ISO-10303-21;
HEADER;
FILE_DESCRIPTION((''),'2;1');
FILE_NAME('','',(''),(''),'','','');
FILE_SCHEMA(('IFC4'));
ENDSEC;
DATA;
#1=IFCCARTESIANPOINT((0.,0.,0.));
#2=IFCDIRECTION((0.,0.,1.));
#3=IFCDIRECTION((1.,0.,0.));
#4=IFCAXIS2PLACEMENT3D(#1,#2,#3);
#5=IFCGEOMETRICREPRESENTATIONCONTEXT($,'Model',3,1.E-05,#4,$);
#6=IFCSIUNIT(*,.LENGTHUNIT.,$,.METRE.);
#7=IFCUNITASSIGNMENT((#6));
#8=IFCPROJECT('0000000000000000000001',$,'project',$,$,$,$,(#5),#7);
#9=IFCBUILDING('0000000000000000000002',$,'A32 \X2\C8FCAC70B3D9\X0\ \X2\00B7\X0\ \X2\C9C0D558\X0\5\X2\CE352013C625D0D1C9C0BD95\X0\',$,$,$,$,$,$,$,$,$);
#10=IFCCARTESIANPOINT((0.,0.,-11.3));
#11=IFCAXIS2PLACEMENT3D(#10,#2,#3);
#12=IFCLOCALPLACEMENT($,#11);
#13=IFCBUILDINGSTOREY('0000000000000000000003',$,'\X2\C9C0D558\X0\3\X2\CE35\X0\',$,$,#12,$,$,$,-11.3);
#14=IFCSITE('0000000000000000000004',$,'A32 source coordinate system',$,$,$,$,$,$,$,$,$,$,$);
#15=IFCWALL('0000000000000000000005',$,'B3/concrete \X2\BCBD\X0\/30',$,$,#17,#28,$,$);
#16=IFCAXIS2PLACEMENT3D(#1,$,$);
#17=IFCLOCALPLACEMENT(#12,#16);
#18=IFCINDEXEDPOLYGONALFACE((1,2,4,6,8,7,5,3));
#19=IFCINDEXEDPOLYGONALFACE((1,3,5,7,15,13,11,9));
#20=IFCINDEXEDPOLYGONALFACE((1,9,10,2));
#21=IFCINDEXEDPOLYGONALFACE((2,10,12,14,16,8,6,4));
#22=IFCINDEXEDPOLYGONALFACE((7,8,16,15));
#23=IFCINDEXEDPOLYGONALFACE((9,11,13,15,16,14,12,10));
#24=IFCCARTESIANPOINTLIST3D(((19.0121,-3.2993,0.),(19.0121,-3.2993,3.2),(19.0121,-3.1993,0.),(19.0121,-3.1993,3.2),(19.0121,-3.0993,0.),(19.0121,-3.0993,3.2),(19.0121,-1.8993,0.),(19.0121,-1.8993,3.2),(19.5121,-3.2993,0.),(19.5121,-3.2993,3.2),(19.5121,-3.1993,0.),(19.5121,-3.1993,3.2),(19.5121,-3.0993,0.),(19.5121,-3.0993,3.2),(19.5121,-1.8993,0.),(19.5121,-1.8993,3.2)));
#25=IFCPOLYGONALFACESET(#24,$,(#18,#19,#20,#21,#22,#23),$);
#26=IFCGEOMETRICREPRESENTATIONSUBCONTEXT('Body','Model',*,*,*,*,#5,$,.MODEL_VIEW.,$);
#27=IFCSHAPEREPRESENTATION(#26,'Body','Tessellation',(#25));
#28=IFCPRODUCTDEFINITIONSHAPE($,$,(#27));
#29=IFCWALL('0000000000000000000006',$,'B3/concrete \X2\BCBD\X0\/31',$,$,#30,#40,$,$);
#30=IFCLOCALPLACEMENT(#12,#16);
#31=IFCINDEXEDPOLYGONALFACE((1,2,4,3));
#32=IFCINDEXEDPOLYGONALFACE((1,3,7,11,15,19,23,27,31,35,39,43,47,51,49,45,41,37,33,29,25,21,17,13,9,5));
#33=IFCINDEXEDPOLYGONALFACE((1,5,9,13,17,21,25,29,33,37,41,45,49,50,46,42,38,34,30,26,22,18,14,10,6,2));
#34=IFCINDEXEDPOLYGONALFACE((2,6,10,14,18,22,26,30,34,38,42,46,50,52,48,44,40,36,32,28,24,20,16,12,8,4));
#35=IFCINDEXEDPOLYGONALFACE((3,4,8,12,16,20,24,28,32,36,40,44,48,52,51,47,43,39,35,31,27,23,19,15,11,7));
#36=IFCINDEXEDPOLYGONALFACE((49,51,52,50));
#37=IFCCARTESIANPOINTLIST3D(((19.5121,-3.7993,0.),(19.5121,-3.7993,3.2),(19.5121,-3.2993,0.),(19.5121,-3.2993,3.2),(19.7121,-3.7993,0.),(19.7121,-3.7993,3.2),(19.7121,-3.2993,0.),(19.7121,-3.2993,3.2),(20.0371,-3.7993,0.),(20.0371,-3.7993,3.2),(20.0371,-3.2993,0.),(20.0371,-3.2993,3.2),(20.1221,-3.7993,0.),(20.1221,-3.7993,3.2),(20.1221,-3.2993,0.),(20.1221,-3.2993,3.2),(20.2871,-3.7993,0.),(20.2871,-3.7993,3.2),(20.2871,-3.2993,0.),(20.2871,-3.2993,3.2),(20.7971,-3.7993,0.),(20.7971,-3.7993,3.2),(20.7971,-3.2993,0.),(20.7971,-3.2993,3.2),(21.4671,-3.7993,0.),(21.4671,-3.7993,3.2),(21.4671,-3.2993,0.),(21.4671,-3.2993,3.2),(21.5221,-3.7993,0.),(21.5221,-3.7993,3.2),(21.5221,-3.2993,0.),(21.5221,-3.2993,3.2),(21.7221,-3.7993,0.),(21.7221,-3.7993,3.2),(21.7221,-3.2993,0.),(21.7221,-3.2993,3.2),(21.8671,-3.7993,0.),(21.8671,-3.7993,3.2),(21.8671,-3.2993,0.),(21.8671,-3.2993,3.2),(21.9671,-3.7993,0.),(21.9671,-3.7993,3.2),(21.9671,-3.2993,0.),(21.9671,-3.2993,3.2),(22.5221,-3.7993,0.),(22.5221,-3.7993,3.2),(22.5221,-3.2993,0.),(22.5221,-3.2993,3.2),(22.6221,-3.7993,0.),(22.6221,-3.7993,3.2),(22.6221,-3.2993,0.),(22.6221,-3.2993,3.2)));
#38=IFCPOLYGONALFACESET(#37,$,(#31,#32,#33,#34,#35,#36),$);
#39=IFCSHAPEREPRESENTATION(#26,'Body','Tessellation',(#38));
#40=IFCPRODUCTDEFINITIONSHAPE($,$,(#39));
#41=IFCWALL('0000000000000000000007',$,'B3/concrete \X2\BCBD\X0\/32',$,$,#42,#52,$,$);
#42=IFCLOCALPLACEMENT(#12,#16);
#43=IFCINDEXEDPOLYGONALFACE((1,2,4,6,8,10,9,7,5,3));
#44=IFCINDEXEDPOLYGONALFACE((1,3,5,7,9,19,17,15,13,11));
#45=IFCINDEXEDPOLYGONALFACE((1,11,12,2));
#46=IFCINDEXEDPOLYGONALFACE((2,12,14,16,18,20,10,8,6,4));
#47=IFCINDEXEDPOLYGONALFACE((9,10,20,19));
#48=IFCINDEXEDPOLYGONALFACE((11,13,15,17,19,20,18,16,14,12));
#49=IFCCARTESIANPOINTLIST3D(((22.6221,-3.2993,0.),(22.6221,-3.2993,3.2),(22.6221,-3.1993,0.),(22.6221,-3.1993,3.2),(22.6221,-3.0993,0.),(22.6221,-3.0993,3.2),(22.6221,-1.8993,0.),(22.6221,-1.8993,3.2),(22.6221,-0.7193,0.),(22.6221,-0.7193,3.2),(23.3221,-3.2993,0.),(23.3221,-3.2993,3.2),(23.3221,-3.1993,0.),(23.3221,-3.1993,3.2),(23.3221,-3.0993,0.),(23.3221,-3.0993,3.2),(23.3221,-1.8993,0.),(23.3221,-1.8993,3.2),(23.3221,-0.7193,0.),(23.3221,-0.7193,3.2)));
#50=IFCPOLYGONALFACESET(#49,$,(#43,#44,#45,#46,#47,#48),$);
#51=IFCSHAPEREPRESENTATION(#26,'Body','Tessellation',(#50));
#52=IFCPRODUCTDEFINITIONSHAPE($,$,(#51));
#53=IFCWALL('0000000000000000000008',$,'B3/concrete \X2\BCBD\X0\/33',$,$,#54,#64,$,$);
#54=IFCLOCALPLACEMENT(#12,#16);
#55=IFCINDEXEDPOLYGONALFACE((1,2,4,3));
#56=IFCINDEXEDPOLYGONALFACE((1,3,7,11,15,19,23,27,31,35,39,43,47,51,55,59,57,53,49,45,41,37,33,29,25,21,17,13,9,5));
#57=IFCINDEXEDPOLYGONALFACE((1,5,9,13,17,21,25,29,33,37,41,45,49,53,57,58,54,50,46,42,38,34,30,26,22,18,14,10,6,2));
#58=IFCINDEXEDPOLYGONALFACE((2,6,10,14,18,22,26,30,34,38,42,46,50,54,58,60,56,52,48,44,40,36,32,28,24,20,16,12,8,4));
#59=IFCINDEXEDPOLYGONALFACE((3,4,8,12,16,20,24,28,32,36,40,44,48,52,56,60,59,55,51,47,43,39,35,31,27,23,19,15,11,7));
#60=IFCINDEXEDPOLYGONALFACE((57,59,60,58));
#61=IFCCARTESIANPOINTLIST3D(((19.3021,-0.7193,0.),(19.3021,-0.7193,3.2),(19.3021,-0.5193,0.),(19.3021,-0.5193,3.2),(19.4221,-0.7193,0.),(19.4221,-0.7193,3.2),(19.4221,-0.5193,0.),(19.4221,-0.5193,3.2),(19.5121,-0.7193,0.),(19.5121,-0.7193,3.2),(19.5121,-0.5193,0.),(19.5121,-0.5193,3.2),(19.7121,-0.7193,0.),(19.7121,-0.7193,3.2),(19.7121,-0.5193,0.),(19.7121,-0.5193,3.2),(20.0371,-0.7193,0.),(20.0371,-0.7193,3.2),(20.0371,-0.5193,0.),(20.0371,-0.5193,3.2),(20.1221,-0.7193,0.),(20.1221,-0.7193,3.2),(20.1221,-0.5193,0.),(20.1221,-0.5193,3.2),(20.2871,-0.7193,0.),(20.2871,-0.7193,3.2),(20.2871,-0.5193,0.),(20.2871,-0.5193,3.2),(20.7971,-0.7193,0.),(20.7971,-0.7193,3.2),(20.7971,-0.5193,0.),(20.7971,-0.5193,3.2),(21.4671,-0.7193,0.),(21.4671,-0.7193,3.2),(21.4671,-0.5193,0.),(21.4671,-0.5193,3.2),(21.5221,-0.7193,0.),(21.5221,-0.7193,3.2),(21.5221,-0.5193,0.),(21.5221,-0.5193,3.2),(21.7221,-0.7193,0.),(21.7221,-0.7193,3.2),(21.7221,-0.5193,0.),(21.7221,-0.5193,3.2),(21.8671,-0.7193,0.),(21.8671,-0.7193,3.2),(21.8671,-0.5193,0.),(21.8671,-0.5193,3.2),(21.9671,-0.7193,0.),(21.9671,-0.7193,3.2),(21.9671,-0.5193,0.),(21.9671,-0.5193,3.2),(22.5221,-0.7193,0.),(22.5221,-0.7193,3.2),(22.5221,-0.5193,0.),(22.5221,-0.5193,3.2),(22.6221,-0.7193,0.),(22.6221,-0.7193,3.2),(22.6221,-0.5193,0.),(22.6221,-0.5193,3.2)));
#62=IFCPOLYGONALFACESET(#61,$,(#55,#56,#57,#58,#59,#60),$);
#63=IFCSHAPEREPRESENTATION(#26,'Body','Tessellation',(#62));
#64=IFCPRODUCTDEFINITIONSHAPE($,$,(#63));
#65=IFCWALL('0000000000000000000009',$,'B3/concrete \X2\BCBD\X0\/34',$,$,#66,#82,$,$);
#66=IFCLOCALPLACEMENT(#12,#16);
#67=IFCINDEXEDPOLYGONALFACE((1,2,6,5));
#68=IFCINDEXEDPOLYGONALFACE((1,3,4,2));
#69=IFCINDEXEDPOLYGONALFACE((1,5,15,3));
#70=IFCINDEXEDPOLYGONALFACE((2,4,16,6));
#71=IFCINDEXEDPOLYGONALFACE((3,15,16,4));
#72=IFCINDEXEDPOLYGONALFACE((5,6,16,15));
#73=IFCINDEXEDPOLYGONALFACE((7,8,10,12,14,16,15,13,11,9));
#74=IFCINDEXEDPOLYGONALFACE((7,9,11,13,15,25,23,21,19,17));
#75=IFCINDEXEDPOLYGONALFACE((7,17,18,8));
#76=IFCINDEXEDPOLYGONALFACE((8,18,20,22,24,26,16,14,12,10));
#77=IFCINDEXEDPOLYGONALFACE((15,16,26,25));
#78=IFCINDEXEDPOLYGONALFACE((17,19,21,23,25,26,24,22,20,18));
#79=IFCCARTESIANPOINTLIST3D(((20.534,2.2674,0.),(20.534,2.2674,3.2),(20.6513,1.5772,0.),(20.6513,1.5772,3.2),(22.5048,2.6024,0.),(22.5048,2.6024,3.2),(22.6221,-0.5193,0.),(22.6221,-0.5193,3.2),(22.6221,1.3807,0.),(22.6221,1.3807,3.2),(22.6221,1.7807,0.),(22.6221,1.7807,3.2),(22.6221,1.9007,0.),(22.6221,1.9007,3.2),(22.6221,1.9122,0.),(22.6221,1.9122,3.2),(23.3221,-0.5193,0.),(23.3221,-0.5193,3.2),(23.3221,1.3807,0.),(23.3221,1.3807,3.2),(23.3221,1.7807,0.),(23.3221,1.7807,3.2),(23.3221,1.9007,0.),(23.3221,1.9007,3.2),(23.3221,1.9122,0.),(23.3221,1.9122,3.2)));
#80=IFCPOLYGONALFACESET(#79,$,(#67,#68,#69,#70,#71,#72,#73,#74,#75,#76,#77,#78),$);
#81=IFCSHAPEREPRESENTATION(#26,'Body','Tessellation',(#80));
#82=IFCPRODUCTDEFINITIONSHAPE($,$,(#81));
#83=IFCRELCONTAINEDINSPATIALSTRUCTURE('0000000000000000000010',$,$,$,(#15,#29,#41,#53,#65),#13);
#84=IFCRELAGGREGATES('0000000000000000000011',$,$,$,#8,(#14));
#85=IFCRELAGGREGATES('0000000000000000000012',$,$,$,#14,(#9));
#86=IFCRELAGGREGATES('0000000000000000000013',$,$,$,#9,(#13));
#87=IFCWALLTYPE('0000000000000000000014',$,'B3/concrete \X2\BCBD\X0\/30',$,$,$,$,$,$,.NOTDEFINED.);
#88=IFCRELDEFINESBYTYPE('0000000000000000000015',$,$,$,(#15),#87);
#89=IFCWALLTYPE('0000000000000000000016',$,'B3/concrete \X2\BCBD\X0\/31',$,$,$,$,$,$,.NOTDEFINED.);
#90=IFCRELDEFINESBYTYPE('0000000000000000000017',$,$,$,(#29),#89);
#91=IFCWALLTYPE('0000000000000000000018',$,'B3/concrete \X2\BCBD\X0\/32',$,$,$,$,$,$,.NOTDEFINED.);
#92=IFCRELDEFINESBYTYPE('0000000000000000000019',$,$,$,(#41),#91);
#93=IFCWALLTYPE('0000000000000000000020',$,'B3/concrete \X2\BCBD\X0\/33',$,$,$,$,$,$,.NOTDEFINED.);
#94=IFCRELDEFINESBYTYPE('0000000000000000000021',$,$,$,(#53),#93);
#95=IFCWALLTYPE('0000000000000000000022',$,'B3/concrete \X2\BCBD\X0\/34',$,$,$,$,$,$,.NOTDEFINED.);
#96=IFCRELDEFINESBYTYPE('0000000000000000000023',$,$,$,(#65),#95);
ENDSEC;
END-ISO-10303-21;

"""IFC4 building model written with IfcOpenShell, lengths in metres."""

from ifc_helpers import new_model, si_unit, frame, origin, origin_with_axes, place, context, subcontext, project, spatial, polyline, outline, extrude, source, transform, mapped, type_object, type_shapes, element, save


model = new_model("IFC4")

# Units and contexts
model_context = context("Model", 3, precision=1e-05, world=origin_with_axes())
body_context = subcontext(model_context, "Body", "Model", "MODEL_VIEW")
ifc_project = project(units=[si_unit("LENGTHUNIT", "METRE")], contexts=[model_context])

# Site, building, storey
site = spatial("IfcSite", under=ifc_project, Name="A32 source coordinate system")
building = spatial("IfcBuilding", under=site, Name="A32 주거동 · 지하5층–옥탑지붕")
storey_placement = place(None, frame((0.0, 0.0, -11.3), z_axis=(0.0, 0.0, 1.0), x_axis=(1.0, 0.0, 0.0)))
storey = spatial("IfcBuildingStorey", under=building, at=storey_placement, Name="지하3층", Elevation=-11.3)

# Walls
wall_type_1 = type_object("IfcWallType", Name="B3/concrete 벽/30", PredefinedType="NOTDEFINED")
shared_shape_1 = source(origin(), body_context, "Body", "SweptSolid", [
    extrude(outline(polyline([(19.0121, -1.8993), (19.5121, -1.8993), (19.5121, -3.0993), (19.5121, -3.1993), (19.5121, -3.2993), (19.0121, -3.2993), (19.0121, -3.1993), (19.0121, -3.0993), (19.0121, -1.8993)])), origin(), (0.0, 0.0, 1.0), 3.2),
])
type_shapes(wall_type_1, [shared_shape_1])
wall_1_placement = place(storey_placement, origin_with_axes())
element("IfcWall", 1, at=wall_1_placement, inside=storey, type_object=wall_type_1, Name="B3/concrete 벽/30", context=body_context, shape_type="MappedRepresentation", body=[
    mapped(shared_shape_1, transform((0.0, 0.0, 0.0), scale=1.0)),
])
wall_type_2 = type_object("IfcWallType", Name="B3/concrete 벽/31", PredefinedType="NOTDEFINED")
shared_shape_2 = source(origin(), body_context, "Body", "SweptSolid", [
    extrude(outline(polyline([(20.1221, -3.2993), (20.2871, -3.2993), (20.7971, -3.2993), (21.4671, -3.2993), (21.5221, -3.2993), (21.7221, -3.2993), (21.8671, -3.2993), (21.9671, -3.2993), (22.5221, -3.2993), (22.6221, -3.2993), (22.6221, -3.7993), (22.5221, -3.7993), (21.9671, -3.7993), (21.8671, -3.7993), (21.7221, -3.7993), (21.5221, -3.7993), (21.4671, -3.7993), (20.7971, -3.7993), (20.2871, -3.7993), (20.1221, -3.7993), (20.0371, -3.7993), (19.7121, -3.7993), (19.5121, -3.7993), (19.5121, -3.2993), (19.7121, -3.2993), (20.0371, -3.2993), (20.1221, -3.2993)])), origin(), (0.0, 0.0, 1.0), 3.2),
])
type_shapes(wall_type_2, [shared_shape_2])
wall_2_placement = place(storey_placement, origin_with_axes())
element("IfcWall", 2, at=wall_2_placement, inside=storey, type_object=wall_type_2, Name="B3/concrete 벽/31", context=body_context, shape_type="MappedRepresentation", body=[
    mapped(shared_shape_2, transform((0.0, 0.0, 0.0), scale=1.0)),
])
wall_type_3 = type_object("IfcWallType", Name="B3/concrete 벽/32", PredefinedType="NOTDEFINED")
shared_shape_3 = source(origin(), body_context, "Body", "SweptSolid", [
    extrude(outline(polyline([(22.6221, -1.8993), (22.6221, -0.7193), (23.3221, -0.7193), (23.3221, -1.8993), (23.3221, -3.0993), (23.3221, -3.1993), (23.3221, -3.2993), (22.6221, -3.2993), (22.6221, -3.1993), (22.6221, -3.0993), (22.6221, -1.8993)])), origin(), (0.0, 0.0, 1.0), 3.2),
])
type_shapes(wall_type_3, [shared_shape_3])
wall_3_placement = place(storey_placement, origin_with_axes())
element("IfcWall", 3, at=wall_3_placement, inside=storey, type_object=wall_type_3, Name="B3/concrete 벽/32", context=body_context, shape_type="MappedRepresentation", body=[
    mapped(shared_shape_3, transform((0.0, 0.0, 0.0), scale=1.0)),
])
wall_type_4 = type_object("IfcWallType", Name="B3/concrete 벽/33", PredefinedType="NOTDEFINED")
shared_shape_4 = source(origin(), body_context, "Body", "SweptSolid", [
    extrude(outline(polyline([(21.8671, -0.7193), (21.7221, -0.7193), (21.5221, -0.7193), (21.4671, -0.7193), (20.7971, -0.7193), (20.2871, -0.7193), (20.1221, -0.7193), (20.0371, -0.7193), (19.7121, -0.7193), (19.5121, -0.7193), (19.4221, -0.7193), (19.3021, -0.7193), (19.3021, -0.5193), (19.4221, -0.5193), (19.5121, -0.5193), (19.7121, -0.5193), (20.0371, -0.5193), (20.1221, -0.5193), (20.2871, -0.5193), (20.7971, -0.5193), (21.4671, -0.5193), (21.5221, -0.5193), (21.7221, -0.5193), (21.8671, -0.5193), (21.9671, -0.5193), (22.5221, -0.5193), (22.6221, -0.5193), (22.6221, -0.7193), (22.5221, -0.7193), (21.9671, -0.7193), (21.8671, -0.7193)])), origin(), (0.0, 0.0, 1.0), 3.2),
])
type_shapes(wall_type_4, [shared_shape_4])
wall_4_placement = place(storey_placement, origin_with_axes())
element("IfcWall", 4, at=wall_4_placement, inside=storey, type_object=wall_type_4, Name="B3/concrete 벽/33", context=body_context, shape_type="MappedRepresentation", body=[
    mapped(shared_shape_4, transform((0.0, 0.0, 0.0), scale=1.0)),
])
wall_type_5 = type_object("IfcWallType", Name="B3/concrete 벽/34", PredefinedType="NOTDEFINED")
shared_shape_5 = source(origin(), body_context, "Body", "SweptSolid", [
    extrude(outline(polyline([(22.6221, 1.9007), (22.6221, 1.9122), (20.6513, 1.5772), (20.534, 2.2674), (22.5048, 2.6024), (22.6221, 1.9122), (23.3221, 1.9122), (23.3221, 1.9007), (23.3221, 1.7807), (23.3221, 1.3807), (23.3221, -0.5193), (22.6221, -0.5193), (22.6221, 1.3807), (22.6221, 1.7807), (22.6221, 1.9007)])), origin(), (0.0, 0.0, 1.0), 3.2),
])
type_shapes(wall_type_5, [shared_shape_5])
wall_5_placement = place(storey_placement, origin_with_axes())
element("IfcWall", 5, at=wall_5_placement, inside=storey, type_object=wall_type_5, Name="B3/concrete 벽/34", context=body_context, shape_type="MappedRepresentation", body=[
    mapped(shared_shape_5, transform((0.0, 0.0, 0.0), scale=1.0)),
])

save(model, "model.ifc")
